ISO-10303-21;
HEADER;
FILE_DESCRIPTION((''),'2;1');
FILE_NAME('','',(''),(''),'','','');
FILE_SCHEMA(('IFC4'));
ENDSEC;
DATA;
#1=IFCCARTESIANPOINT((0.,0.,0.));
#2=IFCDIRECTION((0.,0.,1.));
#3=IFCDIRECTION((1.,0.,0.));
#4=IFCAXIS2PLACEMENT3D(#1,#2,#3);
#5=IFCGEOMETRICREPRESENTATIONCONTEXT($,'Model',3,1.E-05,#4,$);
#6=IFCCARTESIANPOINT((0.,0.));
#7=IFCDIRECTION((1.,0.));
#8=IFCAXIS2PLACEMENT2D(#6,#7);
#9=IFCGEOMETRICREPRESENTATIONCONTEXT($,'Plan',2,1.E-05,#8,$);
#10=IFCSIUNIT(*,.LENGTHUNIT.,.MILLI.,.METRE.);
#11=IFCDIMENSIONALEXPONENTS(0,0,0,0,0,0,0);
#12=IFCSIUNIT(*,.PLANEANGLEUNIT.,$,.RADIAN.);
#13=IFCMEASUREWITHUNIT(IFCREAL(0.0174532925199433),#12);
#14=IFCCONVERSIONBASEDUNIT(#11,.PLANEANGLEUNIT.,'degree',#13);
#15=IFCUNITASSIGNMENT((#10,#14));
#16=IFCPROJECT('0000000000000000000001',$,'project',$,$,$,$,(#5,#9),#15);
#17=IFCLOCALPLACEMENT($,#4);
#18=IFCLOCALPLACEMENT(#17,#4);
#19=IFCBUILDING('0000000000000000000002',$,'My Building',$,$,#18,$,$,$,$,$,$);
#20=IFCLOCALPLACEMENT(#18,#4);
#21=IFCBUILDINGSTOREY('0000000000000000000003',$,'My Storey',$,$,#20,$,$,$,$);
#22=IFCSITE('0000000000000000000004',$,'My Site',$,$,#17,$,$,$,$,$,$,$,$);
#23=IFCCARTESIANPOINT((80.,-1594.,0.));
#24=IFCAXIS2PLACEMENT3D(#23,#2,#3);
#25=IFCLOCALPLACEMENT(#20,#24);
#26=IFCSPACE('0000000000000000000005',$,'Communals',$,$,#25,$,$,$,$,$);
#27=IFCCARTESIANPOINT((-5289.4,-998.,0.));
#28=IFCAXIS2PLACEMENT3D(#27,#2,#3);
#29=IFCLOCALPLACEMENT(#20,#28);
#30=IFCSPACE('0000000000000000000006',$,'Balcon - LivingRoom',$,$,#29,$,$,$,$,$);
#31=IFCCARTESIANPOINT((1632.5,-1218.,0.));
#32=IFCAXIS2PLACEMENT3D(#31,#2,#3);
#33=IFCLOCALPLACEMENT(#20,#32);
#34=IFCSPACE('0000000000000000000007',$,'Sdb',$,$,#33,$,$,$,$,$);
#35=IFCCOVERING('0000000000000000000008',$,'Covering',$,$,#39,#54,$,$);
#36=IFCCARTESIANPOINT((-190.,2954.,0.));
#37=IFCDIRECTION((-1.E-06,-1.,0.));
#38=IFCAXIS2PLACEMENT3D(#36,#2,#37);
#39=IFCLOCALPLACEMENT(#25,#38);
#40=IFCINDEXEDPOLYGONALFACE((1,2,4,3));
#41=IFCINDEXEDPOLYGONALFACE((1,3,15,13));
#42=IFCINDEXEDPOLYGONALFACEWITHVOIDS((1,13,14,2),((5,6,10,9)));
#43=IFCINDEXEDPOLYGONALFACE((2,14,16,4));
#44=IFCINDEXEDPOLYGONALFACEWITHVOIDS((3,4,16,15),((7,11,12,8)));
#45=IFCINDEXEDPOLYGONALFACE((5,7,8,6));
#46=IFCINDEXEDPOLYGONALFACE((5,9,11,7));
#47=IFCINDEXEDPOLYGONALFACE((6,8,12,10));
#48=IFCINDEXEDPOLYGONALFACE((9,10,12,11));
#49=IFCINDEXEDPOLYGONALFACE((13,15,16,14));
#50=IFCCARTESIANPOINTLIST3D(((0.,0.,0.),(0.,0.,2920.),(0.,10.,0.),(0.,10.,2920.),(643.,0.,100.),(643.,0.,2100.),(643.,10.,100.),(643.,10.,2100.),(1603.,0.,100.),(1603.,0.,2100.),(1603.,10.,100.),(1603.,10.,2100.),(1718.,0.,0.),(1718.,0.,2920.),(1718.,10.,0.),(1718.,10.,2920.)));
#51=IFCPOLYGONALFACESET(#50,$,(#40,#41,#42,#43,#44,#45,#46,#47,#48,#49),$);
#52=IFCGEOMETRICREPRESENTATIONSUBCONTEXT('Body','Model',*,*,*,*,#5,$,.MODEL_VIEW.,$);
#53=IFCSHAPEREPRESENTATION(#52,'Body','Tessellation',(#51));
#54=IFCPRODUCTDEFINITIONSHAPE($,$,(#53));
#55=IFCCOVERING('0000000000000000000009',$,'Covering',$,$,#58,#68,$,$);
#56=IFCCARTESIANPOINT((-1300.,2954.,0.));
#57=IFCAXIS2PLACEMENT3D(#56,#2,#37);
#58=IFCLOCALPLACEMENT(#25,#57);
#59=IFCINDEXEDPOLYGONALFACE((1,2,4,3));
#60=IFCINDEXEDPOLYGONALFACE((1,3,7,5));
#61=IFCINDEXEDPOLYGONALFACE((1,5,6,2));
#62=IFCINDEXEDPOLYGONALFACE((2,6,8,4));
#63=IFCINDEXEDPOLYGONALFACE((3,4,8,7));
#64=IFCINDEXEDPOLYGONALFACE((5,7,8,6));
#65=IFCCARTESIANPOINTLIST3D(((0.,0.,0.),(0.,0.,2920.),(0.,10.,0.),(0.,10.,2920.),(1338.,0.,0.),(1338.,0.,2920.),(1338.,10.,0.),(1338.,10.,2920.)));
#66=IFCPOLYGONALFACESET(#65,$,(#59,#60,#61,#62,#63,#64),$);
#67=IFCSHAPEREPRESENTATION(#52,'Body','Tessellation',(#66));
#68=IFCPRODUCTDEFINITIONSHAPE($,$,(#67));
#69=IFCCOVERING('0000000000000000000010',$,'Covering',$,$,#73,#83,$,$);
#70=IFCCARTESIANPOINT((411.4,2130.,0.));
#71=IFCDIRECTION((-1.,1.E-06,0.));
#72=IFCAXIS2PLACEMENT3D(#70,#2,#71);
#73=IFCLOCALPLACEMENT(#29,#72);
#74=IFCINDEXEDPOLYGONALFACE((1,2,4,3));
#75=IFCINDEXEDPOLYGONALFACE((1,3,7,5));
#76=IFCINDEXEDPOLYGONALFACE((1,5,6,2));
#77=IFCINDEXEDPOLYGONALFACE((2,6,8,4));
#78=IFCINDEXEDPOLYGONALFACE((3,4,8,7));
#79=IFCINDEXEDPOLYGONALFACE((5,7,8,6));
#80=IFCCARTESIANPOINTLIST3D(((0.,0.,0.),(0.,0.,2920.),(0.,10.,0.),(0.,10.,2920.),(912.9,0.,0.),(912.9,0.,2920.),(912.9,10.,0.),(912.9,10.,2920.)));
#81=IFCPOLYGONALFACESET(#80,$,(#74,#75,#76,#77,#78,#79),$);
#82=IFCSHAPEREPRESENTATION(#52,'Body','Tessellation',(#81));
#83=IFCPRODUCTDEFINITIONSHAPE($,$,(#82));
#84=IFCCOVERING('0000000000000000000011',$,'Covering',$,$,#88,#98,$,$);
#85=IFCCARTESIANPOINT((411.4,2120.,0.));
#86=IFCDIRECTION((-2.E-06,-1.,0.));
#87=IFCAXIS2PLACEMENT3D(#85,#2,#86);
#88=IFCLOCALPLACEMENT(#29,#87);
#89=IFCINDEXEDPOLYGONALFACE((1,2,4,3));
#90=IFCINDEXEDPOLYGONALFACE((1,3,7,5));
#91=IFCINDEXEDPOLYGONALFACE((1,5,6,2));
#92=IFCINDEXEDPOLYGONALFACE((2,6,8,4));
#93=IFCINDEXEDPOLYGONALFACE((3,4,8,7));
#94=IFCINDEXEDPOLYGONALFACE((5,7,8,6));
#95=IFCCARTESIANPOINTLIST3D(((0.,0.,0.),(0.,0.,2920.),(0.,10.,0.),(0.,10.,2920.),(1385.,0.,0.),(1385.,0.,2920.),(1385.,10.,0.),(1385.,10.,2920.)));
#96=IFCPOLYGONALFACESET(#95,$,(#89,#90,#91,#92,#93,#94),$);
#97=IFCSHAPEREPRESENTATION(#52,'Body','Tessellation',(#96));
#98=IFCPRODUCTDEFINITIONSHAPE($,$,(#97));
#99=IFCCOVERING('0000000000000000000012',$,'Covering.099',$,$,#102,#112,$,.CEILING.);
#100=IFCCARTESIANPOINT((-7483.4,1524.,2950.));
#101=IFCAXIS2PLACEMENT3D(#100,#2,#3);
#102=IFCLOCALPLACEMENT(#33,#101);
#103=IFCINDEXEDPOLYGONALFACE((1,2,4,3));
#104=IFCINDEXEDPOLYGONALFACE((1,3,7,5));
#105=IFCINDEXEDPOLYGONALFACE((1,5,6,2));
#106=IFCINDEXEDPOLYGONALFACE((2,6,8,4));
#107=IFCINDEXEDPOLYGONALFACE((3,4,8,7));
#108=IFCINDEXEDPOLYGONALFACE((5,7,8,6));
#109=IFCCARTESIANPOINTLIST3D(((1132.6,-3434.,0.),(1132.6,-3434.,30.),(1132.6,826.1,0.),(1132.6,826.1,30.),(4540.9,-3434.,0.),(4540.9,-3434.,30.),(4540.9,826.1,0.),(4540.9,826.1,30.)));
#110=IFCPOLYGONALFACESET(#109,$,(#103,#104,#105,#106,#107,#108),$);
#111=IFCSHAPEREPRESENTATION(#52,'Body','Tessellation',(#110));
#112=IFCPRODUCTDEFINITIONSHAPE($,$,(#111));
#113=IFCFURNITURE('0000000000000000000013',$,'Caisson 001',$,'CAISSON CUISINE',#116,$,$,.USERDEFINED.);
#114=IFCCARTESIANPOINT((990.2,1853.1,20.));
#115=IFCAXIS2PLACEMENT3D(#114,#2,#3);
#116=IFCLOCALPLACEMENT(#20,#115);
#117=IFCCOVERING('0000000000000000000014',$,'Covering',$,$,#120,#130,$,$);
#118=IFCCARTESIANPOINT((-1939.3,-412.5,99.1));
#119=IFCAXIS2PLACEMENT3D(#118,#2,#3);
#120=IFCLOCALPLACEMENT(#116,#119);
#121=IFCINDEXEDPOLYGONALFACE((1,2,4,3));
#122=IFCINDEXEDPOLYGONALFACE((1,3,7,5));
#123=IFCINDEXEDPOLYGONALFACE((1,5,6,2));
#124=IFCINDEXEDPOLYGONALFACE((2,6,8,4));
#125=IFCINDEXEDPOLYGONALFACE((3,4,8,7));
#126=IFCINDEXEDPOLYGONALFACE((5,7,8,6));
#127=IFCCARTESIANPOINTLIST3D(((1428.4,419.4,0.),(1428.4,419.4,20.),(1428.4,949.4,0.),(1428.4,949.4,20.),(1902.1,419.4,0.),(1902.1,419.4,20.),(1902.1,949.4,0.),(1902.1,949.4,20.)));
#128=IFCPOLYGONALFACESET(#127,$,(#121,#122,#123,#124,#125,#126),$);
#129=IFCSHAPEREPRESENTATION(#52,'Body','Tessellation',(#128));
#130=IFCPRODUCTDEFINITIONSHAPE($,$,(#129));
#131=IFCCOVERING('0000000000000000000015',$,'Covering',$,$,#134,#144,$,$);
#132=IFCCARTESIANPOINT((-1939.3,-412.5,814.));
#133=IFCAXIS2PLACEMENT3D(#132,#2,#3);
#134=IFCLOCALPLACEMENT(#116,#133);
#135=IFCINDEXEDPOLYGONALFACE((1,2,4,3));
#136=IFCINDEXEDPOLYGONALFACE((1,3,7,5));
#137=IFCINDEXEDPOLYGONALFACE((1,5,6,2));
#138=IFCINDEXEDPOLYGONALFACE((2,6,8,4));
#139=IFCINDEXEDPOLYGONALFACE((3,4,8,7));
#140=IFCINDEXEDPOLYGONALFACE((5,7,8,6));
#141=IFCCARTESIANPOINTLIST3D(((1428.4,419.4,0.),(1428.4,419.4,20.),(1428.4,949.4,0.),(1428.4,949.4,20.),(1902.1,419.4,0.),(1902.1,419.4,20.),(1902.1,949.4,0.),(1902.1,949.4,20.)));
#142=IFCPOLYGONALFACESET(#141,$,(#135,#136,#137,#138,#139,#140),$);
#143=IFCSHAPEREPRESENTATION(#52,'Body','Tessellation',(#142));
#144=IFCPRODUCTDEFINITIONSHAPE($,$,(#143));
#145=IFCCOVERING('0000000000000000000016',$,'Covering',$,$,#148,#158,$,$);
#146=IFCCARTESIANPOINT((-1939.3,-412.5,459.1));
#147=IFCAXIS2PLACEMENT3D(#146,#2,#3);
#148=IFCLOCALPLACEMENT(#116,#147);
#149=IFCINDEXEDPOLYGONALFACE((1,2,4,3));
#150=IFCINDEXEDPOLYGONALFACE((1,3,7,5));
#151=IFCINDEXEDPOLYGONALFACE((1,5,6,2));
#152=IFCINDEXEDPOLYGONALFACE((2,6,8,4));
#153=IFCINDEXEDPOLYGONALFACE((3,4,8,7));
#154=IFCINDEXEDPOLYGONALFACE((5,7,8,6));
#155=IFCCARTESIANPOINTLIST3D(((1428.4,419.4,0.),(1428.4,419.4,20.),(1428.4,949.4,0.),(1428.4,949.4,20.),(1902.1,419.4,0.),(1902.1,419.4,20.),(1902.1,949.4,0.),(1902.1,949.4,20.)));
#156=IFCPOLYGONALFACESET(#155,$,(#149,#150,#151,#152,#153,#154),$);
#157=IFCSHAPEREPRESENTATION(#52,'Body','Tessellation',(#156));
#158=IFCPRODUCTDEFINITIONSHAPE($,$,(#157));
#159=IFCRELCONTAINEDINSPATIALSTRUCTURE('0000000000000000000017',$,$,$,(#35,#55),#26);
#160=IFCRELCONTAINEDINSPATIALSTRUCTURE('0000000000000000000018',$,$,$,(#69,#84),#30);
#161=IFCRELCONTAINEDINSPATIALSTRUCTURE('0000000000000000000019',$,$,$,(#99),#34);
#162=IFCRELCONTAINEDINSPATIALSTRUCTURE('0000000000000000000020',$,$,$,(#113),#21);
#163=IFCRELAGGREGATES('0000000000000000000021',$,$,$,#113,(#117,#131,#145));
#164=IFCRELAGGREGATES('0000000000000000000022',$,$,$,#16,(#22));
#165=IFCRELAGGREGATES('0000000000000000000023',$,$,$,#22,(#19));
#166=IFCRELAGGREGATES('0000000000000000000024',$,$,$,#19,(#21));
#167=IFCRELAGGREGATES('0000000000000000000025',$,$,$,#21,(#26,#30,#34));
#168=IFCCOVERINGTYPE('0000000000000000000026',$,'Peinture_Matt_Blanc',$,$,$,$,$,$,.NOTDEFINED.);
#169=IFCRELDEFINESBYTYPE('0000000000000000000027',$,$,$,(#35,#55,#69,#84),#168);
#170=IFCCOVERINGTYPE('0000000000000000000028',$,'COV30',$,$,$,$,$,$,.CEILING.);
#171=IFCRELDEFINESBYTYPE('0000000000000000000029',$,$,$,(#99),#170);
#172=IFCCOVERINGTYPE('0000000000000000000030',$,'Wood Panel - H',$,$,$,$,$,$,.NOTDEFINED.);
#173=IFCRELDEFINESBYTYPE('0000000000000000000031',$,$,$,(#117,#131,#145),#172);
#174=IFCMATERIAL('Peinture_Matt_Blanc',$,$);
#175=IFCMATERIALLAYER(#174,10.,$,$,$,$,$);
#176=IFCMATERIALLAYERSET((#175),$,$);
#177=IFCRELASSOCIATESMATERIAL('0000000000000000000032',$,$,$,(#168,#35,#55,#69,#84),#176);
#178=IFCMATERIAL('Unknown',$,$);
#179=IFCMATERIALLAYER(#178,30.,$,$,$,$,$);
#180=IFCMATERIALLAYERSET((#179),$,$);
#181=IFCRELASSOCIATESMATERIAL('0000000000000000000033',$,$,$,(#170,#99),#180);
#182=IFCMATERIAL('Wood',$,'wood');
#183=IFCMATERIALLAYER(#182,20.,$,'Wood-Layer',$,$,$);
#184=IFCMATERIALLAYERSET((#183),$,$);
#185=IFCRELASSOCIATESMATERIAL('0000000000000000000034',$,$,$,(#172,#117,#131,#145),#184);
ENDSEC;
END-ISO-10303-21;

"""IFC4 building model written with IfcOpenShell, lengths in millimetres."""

from ifc_helpers import new_model, entity, si_unit, converted_unit, frame, origin_with_axes, origin_2d_with_axis, place, context, subcontext, project, spatial, line, indexed_curve, outline, extrude, clip, halfspace, source, transform, mapped, material, layer, layer_set, layer_usage, type_object, element, aggregate, save


model = new_model("IFC4")

# Units and contexts
model_context = context("Model", 3, precision=1e-05, world=origin_with_axes())
plan_context = context("Plan", 2, precision=1e-05, world=origin_2d_with_axis())
body_context_1 = subcontext(model_context, "Body", "Model", "MODEL_VIEW")
ifc_project = project(units=[si_unit("LENGTHUNIT", "METRE", prefix="MILLI"), converted_unit("PLANEANGLEUNIT", "degree", entity("IfcReal", 0.0174532925199433), si_unit("PLANEANGLEUNIT", "RADIAN"), dimensions=[0, 0, 0, 0, 0, 0, 0])], contexts=[model_context, plan_context])

# Site, building, storey
site_placement = place(None, origin_with_axes())
site = spatial("IfcSite", under=ifc_project, at=site_placement, Name="My Site")
building_placement = place(site_placement, origin_with_axes())
building = spatial("IfcBuilding", under=site, at=building_placement, Name="My Building")
storey_placement = place(building_placement, origin_with_axes())
storey = spatial("IfcBuildingStorey", under=building, at=storey_placement, Name="My Storey")

# Shared definitions
ifc_material_1 = material(Name="Unknown")
shared_shape_1 = source(origin_with_axes(), body_context_1, "Body", "SweptSolid", [
    extrude(outline(indexed_curve([(0.0, 0.0), (960.0, 0.0), (960.0, 2000.0), (0.0, 2000.0)], segments=[line(1, 2, 3, 4, 1)])), frame((0.0, -100.0, 0.0), z_axis=(0.0, -1.0, 0.0), x_axis=(1.0, 0.0, 0.0)), (0.0, 0.0, -1.0), 280.0),
])

# Shared definitions
ifc_material_2 = material(Name="Peinture_Matt_Blanc")
ifc_layer_1 = layer(ifc_material_2, 10.0)
ifc_layer_set_1 = layer_set([ifc_layer_1])
covering_type_1 = type_object("IfcCoveringType", Name="Peinture_Matt_Blanc", PredefinedType="NOTDEFINED", material=ifc_layer_set_1)

# Shared definitions
space_1_placement = place(storey_placement, frame((80.0, -1594.0, 0.0), z_axis=(0.0, 0.0, 1.0), x_axis=(1.0, 0.0, 0.0)))
space_1 = spatial("IfcSpace", under=storey, at=space_1_placement, Name="Communals")

# Covering, opening
ifc_layer_usage_1 = layer_usage(ifc_layer_set_1, "AXIS2", "POSITIVE", 0.0)
covering_1_placement = place(space_1_placement, frame((-190.0, 2954.0, 0.0), z_axis=(0.0, 0.0, 1.0), x_axis=(-0.000001, -1.0, 0.0)))
covering_1 = element("IfcCovering", 1, at=covering_1_placement, inside=space_1, type_object=covering_type_1, material=ifc_layer_usage_1, Name="Covering", context=body_context_1, shape_type="Clipping", body=[
    clip(clip(extrude(outline(indexed_curve([(0.0, 0.0), (0.0, 10.0), (1718.0, 10.0), (1718.0, 0.0), (0.0, 0.0)], self_intersect=False)), origin_with_axes(), (0.0, 0.0, 1.0), 2920.0), halfspace(frame((0.0, 0.0, 2920.0), z_axis=(0.0, 0.0, 1.0), x_axis=(-1.0, 0.0, 0.0)), False)), halfspace(frame((0.0, 0.0, 2920.0), z_axis=(0.0, 0.0, 1.0), x_axis=(-1.0, 0.0, 0.0)), False)),
])
opening_1_placement = place(covering_1_placement, frame((1603.0, 90.0, 100.0), z_axis=(0.0, 0.0, 1.0), x_axis=(-1.0, 0.0, 0.0)))
element("IfcOpeningElement", 2, at=opening_1_placement, cuts=covering_1, PredefinedType="OPENING", context=body_context_1, shape_type="MappedRepresentation", body=[
    mapped(shared_shape_1, transform((0.0, 0.0, 0.0), x_axis=(1.0, 0.0, 0.0), y_axis=(0.0, 1.0, 0.0), z_axis=(0.0, 0.0, 1.0), scale=1.0)),
])

# Covering
ifc_layer_usage_2 = layer_usage(ifc_layer_set_1, "AXIS2", "POSITIVE", 0.0)
covering_2_placement = place(space_1_placement, frame((-1300.0, 2954.0, 0.0), z_axis=(0.0, 0.0, 1.0), x_axis=(-0.000001, -1.0, 0.0)))
element("IfcCovering", 3, at=covering_2_placement, inside=space_1, type_object=covering_type_1, material=ifc_layer_usage_2, Name="Covering", context=body_context_1, shape_type="Clipping", body=[
    clip(clip(extrude(outline(indexed_curve([(0.0, 0.0), (0.0, 10.0), (1338.0, 10.0), (1338.0, 0.0), (0.0, 0.0)], self_intersect=False)), origin_with_axes(), (0.0, 0.0, 1.0), 2920.0), halfspace(frame((0.0, 0.0, 2920.0), z_axis=(0.0, 0.0, 1.0), x_axis=(-1.0, 0.0, 0.0)), False)), halfspace(frame((0.0, 0.0, 2920.0), z_axis=(0.0, 0.0, 1.0), x_axis=(-1.0, 0.0, 0.0)), False)),
])

# Shared definitions
space_2_placement = place(storey_placement, frame((-5289.4, -998.0, 0.0), z_axis=(0.0, 0.0, 1.0), x_axis=(1.0, 0.0, 0.0)))
space_2 = spatial("IfcSpace", under=storey, at=space_2_placement, Name="Balcon - LivingRoom")

# Coverings
ifc_layer_usage_3 = layer_usage(ifc_layer_set_1, "AXIS2", "POSITIVE", 0.0)
covering_3_placement = place(space_2_placement, frame((411.4, 2130.0, 0.0), z_axis=(0.0, 0.0, 1.0), x_axis=(-1.0, 0.000001, 0.0)))
element("IfcCovering", 4, at=covering_3_placement, inside=space_2, type_object=covering_type_1, material=ifc_layer_usage_3, Name="Covering", context=body_context_1, shape_type="Clipping", body=[
    clip(clip(extrude(outline(indexed_curve([(0.0, 0.0), (0.0, 10.0), (912.9, 10.0), (912.9, 0.0), (0.0, 0.0)], self_intersect=False)), origin_with_axes(), (0.0, 0.0, 1.0), 2920.0), halfspace(frame((0.0, 0.0, 2920.0), z_axis=(0.0, 0.0, 1.0), x_axis=(-1.0, 0.0, 0.0)), False)), halfspace(frame((0.0, 0.0, 2920.0), z_axis=(0.0, 0.0, 1.0), x_axis=(-1.0, 0.0, 0.0)), False)),
])
ifc_layer_usage_4 = layer_usage(ifc_layer_set_1, "AXIS2", "POSITIVE", 0.0)
covering_4_placement = place(space_2_placement, frame((411.4, 2120.0, 0.0), z_axis=(0.0, 0.0, 1.0), x_axis=(-0.000002, -1.0, 0.0)))
element("IfcCovering", 5, at=covering_4_placement, inside=space_2, type_object=covering_type_1, material=ifc_layer_usage_4, Name="Covering", context=body_context_1, shape_type="Clipping", body=[
    clip(clip(extrude(outline(indexed_curve([(0.0, 0.0), (0.0, 10.0), (1385.0, 10.0), (1385.0, 0.0), (0.0, 0.0)], self_intersect=False)), origin_with_axes(), (0.0, 0.0, 1.0), 2920.0), halfspace(frame((0.0, 0.0, 2920.0), z_axis=(0.0, 0.0, 1.0), x_axis=(-1.0, 0.0, 0.0)), False)), halfspace(frame((0.0, 0.0, 2920.0), z_axis=(0.0, 0.0, 1.0), x_axis=(-1.0, 0.0, 0.0)), False)),
])

# Shared definitions
space_3_placement = place(storey_placement, frame((1632.5, -1218.0, 0.0), z_axis=(0.0, 0.0, 1.0), x_axis=(1.0, 0.0, 0.0)))
space_3 = spatial("IfcSpace", under=storey, at=space_3_placement, Name="Sdb")

# Covering
ifc_layer_2 = layer(ifc_material_1, 30.0)
ifc_layer_set_2 = layer_set([ifc_layer_2])
ifc_layer_usage_5 = layer_usage(ifc_layer_set_2, "AXIS3", "POSITIVE", 0.0)
covering_type_2 = type_object("IfcCoveringType", Name="COV30", PredefinedType="CEILING", material=ifc_layer_set_2)
covering_5_placement = place(space_3_placement, frame((-7483.4, 1524.0, 2950.0), z_axis=(0.0, 0.0, 1.0), x_axis=(1.0, 0.0, 0.0)))
element("IfcCovering", 6, at=covering_5_placement, inside=space_3, type_object=covering_type_2, material=ifc_layer_usage_5, Name="Covering.099", PredefinedType="CEILING", context=body_context_1, shape_type="SolidModel", body=[
    extrude(outline(indexed_curve([(1132.6, 826.1), (1132.6, -3434.0), (4540.9, -3434.0), (4540.9, 826.1), (1132.6, 826.1)])), None, (0.0, 0.0, 1.0), 30.0),
])

# Furniture, coverings
furniture_placement = place(storey_placement, frame((990.2, 1853.1, 20.0), z_axis=(0.0, 0.0, 1.0), x_axis=(1.0, 0.0, 0.0)))
furniture = element("IfcFurniture", 7, at=furniture_placement, inside=storey, Name="Caisson 001", ObjectType="CAISSON CUISINE", PredefinedType="USERDEFINED")
ifc_material_3 = material(Name="Wood", Category="wood")
ifc_layer_3 = layer(ifc_material_3, 20.0, Name="Wood-Layer")
ifc_layer_set_3 = layer_set([ifc_layer_3])
ifc_layer_usage_6 = layer_usage(ifc_layer_set_3, "AXIS3", "POSITIVE", 0.0)
covering_type_3 = type_object("IfcCoveringType", Name="Wood Panel - H", PredefinedType="NOTDEFINED", material=ifc_layer_set_3)
covering_6_placement = place(furniture_placement, frame((-1939.3, -412.5, 99.1), z_axis=(0.0, 0.0, 1.0), x_axis=(1.0, 0.0, 0.0)))
covering_6 = element("IfcCovering", 8, at=covering_6_placement, type_object=covering_type_3, material=ifc_layer_usage_6, Name="Covering", context=body_context_1, shape_type="SweptSolid", body=[
    extrude(outline(indexed_curve([(1902.1, 419.4), (1428.4, 419.4), (1428.4, 949.4), (1902.1, 949.4), (1902.1, 419.4)])), None, (0.0, 0.0, 1.0), 20.0),
])
ifc_layer_usage_7 = layer_usage(ifc_layer_set_3, "AXIS3", "POSITIVE", 0.0)
covering_7_placement = place(furniture_placement, frame((-1939.3, -412.5, 814.0), z_axis=(0.0, 0.0, 1.0), x_axis=(1.0, 0.0, 0.0)))
covering_7 = element("IfcCovering", 9, at=covering_7_placement, type_object=covering_type_3, material=ifc_layer_usage_7, Name="Covering", context=body_context_1, shape_type="SweptSolid", body=[
    extrude(outline(indexed_curve([(1902.1, 419.4), (1428.4, 419.4), (1428.4, 949.4), (1902.1, 949.4), (1902.1, 419.4)])), None, (0.0, 0.0, 1.0), 20.0),
])
ifc_layer_usage_8 = layer_usage(ifc_layer_set_3, "AXIS3", "POSITIVE", 0.0)
covering_8_placement = place(furniture_placement, frame((-1939.3, -412.5, 459.1), z_axis=(0.0, 0.0, 1.0), x_axis=(1.0, 0.0, 0.0)))
covering_8 = element("IfcCovering", 10, at=covering_8_placement, type_object=covering_type_3, material=ifc_layer_usage_8, Name="Covering", context=body_context_1, shape_type="SweptSolid", body=[
    extrude(outline(indexed_curve([(1902.1, 419.4), (1428.4, 419.4), (1428.4, 949.4), (1902.1, 949.4), (1902.1, 419.4)])), None, (0.0, 0.0, 1.0), 20.0),
])
aggregate(furniture, [covering_6, covering_7, covering_8])

save(model, "model.ifc")
